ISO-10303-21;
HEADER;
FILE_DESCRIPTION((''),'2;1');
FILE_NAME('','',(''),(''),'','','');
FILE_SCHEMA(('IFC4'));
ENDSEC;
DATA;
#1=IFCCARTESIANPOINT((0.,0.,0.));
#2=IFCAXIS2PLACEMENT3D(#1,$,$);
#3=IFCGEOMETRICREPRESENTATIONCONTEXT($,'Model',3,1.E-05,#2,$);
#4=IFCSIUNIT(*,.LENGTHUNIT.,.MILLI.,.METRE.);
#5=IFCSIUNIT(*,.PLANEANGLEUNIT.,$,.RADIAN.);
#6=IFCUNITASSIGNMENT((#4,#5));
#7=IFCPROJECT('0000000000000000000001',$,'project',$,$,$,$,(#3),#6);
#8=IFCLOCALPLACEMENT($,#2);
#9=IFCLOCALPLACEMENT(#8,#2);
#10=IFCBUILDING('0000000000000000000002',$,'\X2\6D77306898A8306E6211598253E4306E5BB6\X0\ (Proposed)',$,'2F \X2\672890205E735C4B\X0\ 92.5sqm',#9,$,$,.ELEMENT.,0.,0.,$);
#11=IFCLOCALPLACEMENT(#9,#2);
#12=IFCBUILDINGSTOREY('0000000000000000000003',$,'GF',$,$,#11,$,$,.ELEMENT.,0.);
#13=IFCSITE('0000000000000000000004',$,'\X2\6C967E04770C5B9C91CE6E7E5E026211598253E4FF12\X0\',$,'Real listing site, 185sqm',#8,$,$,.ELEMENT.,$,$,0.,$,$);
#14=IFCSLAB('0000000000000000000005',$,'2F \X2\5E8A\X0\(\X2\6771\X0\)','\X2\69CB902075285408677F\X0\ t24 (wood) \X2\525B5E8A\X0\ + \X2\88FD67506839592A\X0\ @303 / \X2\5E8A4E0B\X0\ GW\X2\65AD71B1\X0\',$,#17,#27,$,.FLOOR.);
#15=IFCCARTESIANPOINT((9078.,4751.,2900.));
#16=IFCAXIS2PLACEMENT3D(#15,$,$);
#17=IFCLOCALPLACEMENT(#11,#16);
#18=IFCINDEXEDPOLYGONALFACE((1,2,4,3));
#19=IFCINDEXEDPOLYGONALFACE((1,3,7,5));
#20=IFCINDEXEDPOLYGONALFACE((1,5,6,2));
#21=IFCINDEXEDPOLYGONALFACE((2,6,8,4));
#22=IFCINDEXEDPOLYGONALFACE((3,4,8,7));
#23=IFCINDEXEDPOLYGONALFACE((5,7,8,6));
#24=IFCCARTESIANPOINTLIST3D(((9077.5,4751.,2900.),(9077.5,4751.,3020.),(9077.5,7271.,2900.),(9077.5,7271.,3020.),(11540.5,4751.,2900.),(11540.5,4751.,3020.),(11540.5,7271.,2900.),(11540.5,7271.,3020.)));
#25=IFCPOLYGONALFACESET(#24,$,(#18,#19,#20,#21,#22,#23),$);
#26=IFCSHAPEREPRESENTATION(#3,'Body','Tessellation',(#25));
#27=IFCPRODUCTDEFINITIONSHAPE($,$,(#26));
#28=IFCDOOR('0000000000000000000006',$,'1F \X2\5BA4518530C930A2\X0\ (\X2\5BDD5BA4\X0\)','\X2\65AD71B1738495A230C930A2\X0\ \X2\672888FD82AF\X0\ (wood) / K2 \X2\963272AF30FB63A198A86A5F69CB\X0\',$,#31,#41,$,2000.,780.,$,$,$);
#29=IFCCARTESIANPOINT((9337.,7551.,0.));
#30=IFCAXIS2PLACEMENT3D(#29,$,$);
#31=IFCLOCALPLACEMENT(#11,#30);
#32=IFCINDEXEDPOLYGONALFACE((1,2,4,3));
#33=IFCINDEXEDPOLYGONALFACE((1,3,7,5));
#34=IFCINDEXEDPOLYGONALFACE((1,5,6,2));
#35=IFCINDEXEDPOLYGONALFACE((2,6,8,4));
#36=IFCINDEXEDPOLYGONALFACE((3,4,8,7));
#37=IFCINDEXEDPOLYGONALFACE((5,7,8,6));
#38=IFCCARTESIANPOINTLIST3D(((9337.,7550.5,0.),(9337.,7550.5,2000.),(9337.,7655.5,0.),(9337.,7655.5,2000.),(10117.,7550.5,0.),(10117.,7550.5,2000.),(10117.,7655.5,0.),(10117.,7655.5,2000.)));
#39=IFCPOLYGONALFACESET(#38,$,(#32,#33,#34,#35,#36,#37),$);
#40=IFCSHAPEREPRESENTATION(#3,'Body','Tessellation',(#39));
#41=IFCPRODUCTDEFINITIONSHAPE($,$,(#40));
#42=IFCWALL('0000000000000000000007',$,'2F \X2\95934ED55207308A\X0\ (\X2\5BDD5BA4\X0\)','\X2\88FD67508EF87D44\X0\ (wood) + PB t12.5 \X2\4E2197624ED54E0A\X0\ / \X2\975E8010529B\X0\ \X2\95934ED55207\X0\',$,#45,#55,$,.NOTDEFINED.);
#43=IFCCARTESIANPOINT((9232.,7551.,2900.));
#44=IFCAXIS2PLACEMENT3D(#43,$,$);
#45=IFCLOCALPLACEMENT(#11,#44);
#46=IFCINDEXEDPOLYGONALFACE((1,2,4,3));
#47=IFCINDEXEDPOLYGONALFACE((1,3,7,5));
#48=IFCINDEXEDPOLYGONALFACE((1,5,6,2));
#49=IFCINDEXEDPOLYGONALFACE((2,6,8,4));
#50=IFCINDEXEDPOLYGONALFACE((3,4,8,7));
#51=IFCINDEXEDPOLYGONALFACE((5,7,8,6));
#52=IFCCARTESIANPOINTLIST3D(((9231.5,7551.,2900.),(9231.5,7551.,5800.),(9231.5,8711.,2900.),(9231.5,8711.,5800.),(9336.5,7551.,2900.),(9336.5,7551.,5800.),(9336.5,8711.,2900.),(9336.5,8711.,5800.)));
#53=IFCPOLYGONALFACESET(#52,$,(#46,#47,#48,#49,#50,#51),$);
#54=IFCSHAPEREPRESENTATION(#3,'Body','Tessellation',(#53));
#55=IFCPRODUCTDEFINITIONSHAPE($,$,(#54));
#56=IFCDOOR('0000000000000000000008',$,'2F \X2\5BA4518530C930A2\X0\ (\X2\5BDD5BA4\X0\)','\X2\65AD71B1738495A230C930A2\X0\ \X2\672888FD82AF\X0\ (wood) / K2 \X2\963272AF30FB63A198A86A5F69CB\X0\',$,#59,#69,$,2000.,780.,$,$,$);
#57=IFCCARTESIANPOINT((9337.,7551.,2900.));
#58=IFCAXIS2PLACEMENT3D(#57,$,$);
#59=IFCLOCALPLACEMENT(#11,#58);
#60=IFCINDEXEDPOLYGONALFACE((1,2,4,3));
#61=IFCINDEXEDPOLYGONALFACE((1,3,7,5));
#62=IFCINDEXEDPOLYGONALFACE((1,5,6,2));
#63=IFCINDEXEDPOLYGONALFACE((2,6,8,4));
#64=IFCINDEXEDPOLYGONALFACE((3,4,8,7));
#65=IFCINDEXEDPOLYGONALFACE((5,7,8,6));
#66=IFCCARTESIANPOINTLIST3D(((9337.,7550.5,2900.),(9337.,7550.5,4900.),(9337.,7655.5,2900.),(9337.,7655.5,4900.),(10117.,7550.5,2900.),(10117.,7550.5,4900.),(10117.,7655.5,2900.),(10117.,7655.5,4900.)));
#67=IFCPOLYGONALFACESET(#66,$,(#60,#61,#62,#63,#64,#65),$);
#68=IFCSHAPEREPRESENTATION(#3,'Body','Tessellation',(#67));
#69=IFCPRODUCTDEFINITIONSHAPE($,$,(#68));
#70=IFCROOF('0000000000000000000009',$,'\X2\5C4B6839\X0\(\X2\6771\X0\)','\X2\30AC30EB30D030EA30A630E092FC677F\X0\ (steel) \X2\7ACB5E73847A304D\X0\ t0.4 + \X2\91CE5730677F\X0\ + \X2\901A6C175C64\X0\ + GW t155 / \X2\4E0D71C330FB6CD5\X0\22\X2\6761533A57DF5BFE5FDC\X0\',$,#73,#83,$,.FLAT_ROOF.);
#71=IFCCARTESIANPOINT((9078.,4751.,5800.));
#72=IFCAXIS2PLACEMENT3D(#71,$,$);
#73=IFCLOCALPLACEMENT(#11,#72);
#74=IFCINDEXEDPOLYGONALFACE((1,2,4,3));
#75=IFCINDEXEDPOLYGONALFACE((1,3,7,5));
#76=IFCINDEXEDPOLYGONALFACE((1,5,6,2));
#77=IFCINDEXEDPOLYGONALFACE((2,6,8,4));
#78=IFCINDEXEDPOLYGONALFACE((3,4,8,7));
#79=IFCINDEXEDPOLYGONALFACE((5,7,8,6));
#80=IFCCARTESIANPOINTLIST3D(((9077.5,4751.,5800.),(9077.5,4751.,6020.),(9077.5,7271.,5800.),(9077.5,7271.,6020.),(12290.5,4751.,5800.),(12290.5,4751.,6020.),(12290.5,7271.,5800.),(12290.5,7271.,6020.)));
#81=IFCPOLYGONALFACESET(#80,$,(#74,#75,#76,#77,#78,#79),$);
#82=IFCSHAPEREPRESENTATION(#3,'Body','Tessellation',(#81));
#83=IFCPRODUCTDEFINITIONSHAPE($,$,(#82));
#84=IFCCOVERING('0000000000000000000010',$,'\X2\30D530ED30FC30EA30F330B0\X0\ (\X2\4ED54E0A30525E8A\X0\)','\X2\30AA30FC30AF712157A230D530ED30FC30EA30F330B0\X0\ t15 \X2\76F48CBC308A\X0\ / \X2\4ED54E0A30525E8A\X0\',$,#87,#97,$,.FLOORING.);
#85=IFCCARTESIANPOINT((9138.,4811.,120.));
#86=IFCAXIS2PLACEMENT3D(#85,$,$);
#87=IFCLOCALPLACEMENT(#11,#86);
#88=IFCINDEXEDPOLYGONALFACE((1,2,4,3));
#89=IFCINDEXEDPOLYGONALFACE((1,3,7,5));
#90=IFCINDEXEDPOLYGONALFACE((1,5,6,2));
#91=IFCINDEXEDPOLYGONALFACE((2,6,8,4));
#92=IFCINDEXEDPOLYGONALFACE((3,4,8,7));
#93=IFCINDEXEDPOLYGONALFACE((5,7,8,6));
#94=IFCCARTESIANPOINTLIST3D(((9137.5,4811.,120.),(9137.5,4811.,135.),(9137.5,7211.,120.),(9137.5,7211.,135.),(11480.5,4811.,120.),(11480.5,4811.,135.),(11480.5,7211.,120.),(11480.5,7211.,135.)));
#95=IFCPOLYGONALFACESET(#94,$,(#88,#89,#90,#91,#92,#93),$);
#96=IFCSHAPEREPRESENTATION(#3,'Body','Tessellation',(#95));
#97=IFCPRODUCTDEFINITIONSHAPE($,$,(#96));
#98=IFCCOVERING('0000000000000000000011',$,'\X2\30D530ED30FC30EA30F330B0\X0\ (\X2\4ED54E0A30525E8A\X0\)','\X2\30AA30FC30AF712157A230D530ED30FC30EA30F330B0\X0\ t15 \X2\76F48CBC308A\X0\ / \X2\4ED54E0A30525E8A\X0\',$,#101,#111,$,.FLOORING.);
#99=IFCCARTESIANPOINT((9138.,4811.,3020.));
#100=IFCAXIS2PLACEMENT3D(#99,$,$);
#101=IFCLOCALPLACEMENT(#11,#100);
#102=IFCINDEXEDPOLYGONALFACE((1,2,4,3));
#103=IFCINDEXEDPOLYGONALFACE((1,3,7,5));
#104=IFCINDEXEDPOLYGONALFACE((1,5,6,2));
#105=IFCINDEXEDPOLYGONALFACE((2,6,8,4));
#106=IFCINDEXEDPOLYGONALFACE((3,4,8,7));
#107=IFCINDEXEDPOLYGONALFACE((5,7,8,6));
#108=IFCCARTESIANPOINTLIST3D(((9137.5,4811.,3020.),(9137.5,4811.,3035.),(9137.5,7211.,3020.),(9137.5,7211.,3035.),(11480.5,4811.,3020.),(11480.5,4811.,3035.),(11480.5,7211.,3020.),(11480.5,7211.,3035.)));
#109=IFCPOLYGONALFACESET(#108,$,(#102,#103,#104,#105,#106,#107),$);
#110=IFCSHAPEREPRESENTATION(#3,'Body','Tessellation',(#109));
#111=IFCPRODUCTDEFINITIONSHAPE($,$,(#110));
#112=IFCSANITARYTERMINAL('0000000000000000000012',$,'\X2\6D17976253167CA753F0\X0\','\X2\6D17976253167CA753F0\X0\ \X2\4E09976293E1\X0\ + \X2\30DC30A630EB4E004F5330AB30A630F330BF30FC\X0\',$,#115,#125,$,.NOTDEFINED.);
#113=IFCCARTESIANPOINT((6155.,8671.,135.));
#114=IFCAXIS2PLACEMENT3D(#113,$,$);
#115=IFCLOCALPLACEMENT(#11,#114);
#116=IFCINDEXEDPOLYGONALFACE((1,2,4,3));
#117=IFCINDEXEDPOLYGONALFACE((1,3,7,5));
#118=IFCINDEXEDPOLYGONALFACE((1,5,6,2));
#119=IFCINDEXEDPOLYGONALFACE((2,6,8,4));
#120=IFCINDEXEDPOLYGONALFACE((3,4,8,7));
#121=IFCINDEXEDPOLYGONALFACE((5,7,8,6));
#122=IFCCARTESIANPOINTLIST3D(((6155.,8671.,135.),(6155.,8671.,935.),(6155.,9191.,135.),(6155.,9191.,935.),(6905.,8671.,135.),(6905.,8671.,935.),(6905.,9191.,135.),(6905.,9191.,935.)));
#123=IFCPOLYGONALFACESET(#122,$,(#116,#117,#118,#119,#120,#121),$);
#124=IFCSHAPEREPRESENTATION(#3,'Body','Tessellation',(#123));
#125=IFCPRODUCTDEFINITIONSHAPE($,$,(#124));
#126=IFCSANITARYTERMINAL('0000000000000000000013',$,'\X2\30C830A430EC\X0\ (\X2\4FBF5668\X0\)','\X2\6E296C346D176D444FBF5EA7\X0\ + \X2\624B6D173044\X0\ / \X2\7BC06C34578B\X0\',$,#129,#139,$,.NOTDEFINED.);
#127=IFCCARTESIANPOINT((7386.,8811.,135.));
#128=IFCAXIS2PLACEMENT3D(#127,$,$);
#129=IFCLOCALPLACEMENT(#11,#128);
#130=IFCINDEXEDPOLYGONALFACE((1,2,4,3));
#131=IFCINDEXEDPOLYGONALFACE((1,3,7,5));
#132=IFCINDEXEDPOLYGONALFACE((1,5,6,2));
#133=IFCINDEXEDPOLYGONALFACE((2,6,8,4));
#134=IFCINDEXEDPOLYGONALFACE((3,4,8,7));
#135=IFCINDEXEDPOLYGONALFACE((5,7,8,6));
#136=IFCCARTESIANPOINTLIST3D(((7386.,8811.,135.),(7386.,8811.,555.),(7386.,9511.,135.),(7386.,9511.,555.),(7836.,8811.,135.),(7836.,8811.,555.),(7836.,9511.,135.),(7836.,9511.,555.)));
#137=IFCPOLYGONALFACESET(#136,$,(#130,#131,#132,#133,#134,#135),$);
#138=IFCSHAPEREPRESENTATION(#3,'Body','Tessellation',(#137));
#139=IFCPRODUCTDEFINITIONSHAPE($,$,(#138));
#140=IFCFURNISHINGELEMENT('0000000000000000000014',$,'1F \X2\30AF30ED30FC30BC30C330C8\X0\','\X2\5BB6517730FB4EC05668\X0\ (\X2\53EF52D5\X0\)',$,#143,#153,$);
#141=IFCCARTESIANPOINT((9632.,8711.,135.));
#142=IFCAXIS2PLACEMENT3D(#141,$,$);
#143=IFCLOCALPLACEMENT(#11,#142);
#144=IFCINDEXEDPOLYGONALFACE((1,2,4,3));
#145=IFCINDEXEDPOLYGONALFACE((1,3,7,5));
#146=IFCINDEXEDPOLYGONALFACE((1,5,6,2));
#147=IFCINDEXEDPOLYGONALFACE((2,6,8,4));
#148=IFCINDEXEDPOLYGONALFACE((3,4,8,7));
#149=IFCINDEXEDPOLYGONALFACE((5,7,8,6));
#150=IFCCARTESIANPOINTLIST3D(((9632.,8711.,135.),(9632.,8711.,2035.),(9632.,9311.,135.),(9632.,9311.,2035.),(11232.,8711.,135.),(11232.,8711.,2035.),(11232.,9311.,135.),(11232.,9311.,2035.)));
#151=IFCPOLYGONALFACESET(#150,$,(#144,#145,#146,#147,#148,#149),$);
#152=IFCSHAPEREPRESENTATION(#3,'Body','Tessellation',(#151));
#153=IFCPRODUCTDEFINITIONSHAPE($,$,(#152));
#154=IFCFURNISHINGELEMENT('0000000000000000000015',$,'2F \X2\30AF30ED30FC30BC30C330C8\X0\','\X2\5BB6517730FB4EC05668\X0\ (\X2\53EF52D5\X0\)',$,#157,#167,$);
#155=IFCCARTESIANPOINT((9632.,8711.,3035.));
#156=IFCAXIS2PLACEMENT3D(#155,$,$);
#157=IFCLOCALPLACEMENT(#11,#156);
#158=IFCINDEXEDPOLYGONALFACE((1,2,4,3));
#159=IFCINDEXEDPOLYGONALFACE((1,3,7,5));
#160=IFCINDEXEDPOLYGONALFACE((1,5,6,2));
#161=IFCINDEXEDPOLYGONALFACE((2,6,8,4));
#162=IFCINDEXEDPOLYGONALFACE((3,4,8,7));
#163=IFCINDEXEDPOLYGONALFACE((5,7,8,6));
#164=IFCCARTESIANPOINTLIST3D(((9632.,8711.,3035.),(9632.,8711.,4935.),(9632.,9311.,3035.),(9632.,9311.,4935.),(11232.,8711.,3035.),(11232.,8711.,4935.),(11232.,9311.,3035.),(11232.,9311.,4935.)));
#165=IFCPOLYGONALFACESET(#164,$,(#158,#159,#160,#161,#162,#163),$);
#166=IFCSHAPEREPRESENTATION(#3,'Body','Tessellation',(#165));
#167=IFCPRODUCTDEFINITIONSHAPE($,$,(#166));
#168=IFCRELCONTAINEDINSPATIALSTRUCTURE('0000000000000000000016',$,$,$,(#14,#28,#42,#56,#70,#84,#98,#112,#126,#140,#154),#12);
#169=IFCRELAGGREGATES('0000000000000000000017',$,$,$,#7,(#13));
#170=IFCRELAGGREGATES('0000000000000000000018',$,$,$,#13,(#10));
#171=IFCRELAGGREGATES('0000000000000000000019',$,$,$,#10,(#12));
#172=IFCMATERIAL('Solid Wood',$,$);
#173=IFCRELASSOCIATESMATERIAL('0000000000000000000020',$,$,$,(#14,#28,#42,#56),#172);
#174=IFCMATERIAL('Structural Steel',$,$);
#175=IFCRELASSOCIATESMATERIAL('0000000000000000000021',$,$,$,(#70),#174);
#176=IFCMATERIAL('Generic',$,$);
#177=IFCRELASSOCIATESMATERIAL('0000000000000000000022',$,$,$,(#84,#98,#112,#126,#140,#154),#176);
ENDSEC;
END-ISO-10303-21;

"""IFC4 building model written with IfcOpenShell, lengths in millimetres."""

from ifc_helpers import new_model, si_unit, frame, frame_2d, origin, place, context, project, spatial, rectangle, extrude, material, element, save


model = new_model("IFC4")

# Units and contexts
model_context = context("Model", 3, precision=1e-05, world=origin())
ifc_project = project(units=[si_unit("LENGTHUNIT", "METRE", prefix="MILLI"), si_unit("PLANEANGLEUNIT", "RADIAN")], contexts=[model_context])

# Site, building, storey
site_placement = place(None, origin())
site = spatial("IfcSite", under=ifc_project, at=site_placement, Name="沖縄県宜野湾市我如古２", ObjectType="Real listing site, 185sqm", CompositionType="ELEMENT", RefElevation=0.0)
building_placement = place(site_placement, origin())
building = spatial("IfcBuilding", under=site, at=building_placement, Name="海と風の我如古の家 (Proposed)", ObjectType="2F 木造平屋 92.5sqm", CompositionType="ELEMENT", ElevationOfRefHeight=0.0, ElevationOfTerrain=0.0)
storey_placement = place(building_placement, origin())
storey = spatial("IfcBuildingStorey", under=building, at=storey_placement, Name="GF", CompositionType="ELEMENT", Elevation=0.0)

# Slab
ifc_material_1 = material(Name="Solid Wood")
slab_1_placement = place(storey_placement, frame((9078.0, 4751.0, 2900.0)))
element("IfcSlab", 1, at=slab_1_placement, inside=storey, material=ifc_material_1, Name="2F 床(東)", Description="構造用合板 t24 (wood) 剛床 + 製材根太 @303 / 床下 GW断熱", PredefinedType="FLOOR", context=model_context, shape_type="SweptSolid", body=[
    extrude(rectangle(XDim=2463.0, YDim=2520.0, at=frame_2d((1231.0, 1260.0))), frame((9078.0, 4751.0, 2900.0)), (0.0, 0.0, 1.0), 120.0),
])

# Door
door_1_placement = place(storey_placement, frame((9337.0, 7551.0, 0.0)))
element("IfcDoor", 2, at=door_1_placement, inside=storey, material=ifc_material_1, Name="1F 室内ドア (寝室)", Description="断熱玄関ドア 木製芯 (wood) / K2 防犯・採風機構", OverallHeight=2000.0, OverallWidth=780.0, context=model_context, shape_type="SweptSolid", body=[
    extrude(rectangle(XDim=780.0, YDim=105.0, at=frame_2d((390.0, 52.0))), frame((9337.0, 7551.0, 0.0)), (0.0, 0.0, 1.0), 2000.0),
])

# Wall
wall_1_placement = place(storey_placement, frame((9232.0, 7551.0, 2900.0)))
element("IfcWall", 3, at=wall_1_placement, inside=storey, material=ifc_material_1, Name="2F 間仕切り (寝室)", Description="製材軸組 (wood) + PB t12.5 両面仕上 / 非耐力 間仕切", PredefinedType="NOTDEFINED", context=model_context, shape_type="SweptSolid", body=[
    extrude(rectangle(XDim=105.0, YDim=1160.0, at=frame_2d((52.0, 580.0))), frame((9232.0, 7551.0, 2900.0)), (0.0, 0.0, 1.0), 2900.0),
])

# Door
door_2_placement = place(storey_placement, frame((9337.0, 7551.0, 2900.0)))
element("IfcDoor", 4, at=door_2_placement, inside=storey, material=ifc_material_1, Name="2F 室内ドア (寝室)", Description="断熱玄関ドア 木製芯 (wood) / K2 防犯・採風機構", OverallHeight=2000.0, OverallWidth=780.0, context=model_context, shape_type="SweptSolid", body=[
    extrude(rectangle(XDim=780.0, YDim=105.0, at=frame_2d((390.0, 52.0))), frame((9337.0, 7551.0, 2900.0)), (0.0, 0.0, 1.0), 2000.0),
])

# Roof
ifc_material_2 = material(Name="Structural Steel")
for number, where, name in (
    (5, (9078.0, 4751.0, 5800.0), "屋根(東)"),
):
    element("IfcRoof", number, at=place(storey_placement, frame(where)), inside=storey, material=ifc_material_2, Name=name, Description="ガルバリウム鋼板 (steel) 立平葺き t0.4 + 野地板 + 通気層 + GW t155 / 不燃・法22条区域対応", PredefinedType="FLAT_ROOF", context=model_context, shape_type="SweptSolid", body=[
        extrude(rectangle(XDim=3213.0, YDim=2520.0, at=frame_2d((1606.0, 1260.0))), frame((9078.0, 4751.0, 5800.0)), (0.0, 0.0, 1.0), 220.0),
    ])

# Coverings
ifc_material_3 = material(Name="Generic")
covering_1_placement = place(storey_placement, frame((9138.0, 4811.0, 120.0)))
element("IfcCovering", 6, at=covering_1_placement, inside=storey, material=ifc_material_3, Name="フローリング (仕上げ床)", Description="オーク無垢フローリング t15 直貼り / 仕上げ床", PredefinedType="FLOORING", context=model_context, shape_type="SweptSolid", body=[
    extrude(rectangle(XDim=2343.0, YDim=2400.0, at=frame_2d((1171.0, 1200.0))), frame((9138.0, 4811.0, 120.0)), (0.0, 0.0, 1.0), 15.0),
])
covering_2_placement = place(storey_placement, frame((9138.0, 4811.0, 3020.0)))
element("IfcCovering", 7, at=covering_2_placement, inside=storey, material=ifc_material_3, Name="フローリング (仕上げ床)", Description="オーク無垢フローリング t15 直貼り / 仕上げ床", PredefinedType="FLOORING", context=model_context, shape_type="SweptSolid", body=[
    extrude(rectangle(XDim=2343.0, YDim=2400.0, at=frame_2d((1171.0, 1200.0))), frame((9138.0, 4811.0, 3020.0)), (0.0, 0.0, 1.0), 15.0),
])

# Sanitary terminals
sanitary_terminal_1_placement = place(storey_placement, frame((6155.0, 8671.0, 135.0)))
element("IfcSanitaryTerminal", 8, at=sanitary_terminal_1_placement, inside=storey, material=ifc_material_3, Name="洗面化粧台", Description="洗面化粧台 三面鏡 + ボウル一体カウンター", PredefinedType="NOTDEFINED", context=model_context, shape_type="SweptSolid", body=[
    extrude(rectangle(XDim=750.0, YDim=520.0, at=frame_2d((375.0, 260.0))), frame((6155.0, 8671.0, 135.0)), (0.0, 0.0, 1.0), 800.0),
])
sanitary_terminal_2_placement = place(storey_placement, frame((7386.0, 8811.0, 135.0)))
element("IfcSanitaryTerminal", 9, at=sanitary_terminal_2_placement, inside=storey, material=ifc_material_3, Name="トイレ (便器)", Description="温水洗浄便座 + 手洗い / 節水型", PredefinedType="NOTDEFINED", context=model_context, shape_type="SweptSolid", body=[
    extrude(rectangle(XDim=450.0, YDim=700.0, at=frame_2d((225.0, 350.0))), frame((7386.0, 8811.0, 135.0)), (0.0, 0.0, 1.0), 420.0),
])

# Furnishing elements
furnishing_1_placement = place(storey_placement, frame((9632.0, 8711.0, 135.0)))
element("IfcFurnishingElement", 10, at=furnishing_1_placement, inside=storey, material=ifc_material_3, Name="1F クローゼット", Description="家具・什器 (可動)", context=model_context, shape_type="SweptSolid", body=[
    extrude(rectangle(XDim=1600.0, YDim=600.0, at=frame_2d((800.0, 300.0))), frame((9632.0, 8711.0, 135.0)), (0.0, 0.0, 1.0), 1900.0),
])
furnishing_2_placement = place(storey_placement, frame((9632.0, 8711.0, 3035.0)))
element("IfcFurnishingElement", 11, at=furnishing_2_placement, inside=storey, material=ifc_material_3, Name="2F クローゼット", Description="家具・什器 (可動)", context=model_context, shape_type="SweptSolid", body=[
    extrude(rectangle(XDim=1600.0, YDim=600.0, at=frame_2d((800.0, 300.0))), frame((9632.0, 8711.0, 3035.0)), (0.0, 0.0, 1.0), 1900.0),
])

save(model, "model.ifc")
